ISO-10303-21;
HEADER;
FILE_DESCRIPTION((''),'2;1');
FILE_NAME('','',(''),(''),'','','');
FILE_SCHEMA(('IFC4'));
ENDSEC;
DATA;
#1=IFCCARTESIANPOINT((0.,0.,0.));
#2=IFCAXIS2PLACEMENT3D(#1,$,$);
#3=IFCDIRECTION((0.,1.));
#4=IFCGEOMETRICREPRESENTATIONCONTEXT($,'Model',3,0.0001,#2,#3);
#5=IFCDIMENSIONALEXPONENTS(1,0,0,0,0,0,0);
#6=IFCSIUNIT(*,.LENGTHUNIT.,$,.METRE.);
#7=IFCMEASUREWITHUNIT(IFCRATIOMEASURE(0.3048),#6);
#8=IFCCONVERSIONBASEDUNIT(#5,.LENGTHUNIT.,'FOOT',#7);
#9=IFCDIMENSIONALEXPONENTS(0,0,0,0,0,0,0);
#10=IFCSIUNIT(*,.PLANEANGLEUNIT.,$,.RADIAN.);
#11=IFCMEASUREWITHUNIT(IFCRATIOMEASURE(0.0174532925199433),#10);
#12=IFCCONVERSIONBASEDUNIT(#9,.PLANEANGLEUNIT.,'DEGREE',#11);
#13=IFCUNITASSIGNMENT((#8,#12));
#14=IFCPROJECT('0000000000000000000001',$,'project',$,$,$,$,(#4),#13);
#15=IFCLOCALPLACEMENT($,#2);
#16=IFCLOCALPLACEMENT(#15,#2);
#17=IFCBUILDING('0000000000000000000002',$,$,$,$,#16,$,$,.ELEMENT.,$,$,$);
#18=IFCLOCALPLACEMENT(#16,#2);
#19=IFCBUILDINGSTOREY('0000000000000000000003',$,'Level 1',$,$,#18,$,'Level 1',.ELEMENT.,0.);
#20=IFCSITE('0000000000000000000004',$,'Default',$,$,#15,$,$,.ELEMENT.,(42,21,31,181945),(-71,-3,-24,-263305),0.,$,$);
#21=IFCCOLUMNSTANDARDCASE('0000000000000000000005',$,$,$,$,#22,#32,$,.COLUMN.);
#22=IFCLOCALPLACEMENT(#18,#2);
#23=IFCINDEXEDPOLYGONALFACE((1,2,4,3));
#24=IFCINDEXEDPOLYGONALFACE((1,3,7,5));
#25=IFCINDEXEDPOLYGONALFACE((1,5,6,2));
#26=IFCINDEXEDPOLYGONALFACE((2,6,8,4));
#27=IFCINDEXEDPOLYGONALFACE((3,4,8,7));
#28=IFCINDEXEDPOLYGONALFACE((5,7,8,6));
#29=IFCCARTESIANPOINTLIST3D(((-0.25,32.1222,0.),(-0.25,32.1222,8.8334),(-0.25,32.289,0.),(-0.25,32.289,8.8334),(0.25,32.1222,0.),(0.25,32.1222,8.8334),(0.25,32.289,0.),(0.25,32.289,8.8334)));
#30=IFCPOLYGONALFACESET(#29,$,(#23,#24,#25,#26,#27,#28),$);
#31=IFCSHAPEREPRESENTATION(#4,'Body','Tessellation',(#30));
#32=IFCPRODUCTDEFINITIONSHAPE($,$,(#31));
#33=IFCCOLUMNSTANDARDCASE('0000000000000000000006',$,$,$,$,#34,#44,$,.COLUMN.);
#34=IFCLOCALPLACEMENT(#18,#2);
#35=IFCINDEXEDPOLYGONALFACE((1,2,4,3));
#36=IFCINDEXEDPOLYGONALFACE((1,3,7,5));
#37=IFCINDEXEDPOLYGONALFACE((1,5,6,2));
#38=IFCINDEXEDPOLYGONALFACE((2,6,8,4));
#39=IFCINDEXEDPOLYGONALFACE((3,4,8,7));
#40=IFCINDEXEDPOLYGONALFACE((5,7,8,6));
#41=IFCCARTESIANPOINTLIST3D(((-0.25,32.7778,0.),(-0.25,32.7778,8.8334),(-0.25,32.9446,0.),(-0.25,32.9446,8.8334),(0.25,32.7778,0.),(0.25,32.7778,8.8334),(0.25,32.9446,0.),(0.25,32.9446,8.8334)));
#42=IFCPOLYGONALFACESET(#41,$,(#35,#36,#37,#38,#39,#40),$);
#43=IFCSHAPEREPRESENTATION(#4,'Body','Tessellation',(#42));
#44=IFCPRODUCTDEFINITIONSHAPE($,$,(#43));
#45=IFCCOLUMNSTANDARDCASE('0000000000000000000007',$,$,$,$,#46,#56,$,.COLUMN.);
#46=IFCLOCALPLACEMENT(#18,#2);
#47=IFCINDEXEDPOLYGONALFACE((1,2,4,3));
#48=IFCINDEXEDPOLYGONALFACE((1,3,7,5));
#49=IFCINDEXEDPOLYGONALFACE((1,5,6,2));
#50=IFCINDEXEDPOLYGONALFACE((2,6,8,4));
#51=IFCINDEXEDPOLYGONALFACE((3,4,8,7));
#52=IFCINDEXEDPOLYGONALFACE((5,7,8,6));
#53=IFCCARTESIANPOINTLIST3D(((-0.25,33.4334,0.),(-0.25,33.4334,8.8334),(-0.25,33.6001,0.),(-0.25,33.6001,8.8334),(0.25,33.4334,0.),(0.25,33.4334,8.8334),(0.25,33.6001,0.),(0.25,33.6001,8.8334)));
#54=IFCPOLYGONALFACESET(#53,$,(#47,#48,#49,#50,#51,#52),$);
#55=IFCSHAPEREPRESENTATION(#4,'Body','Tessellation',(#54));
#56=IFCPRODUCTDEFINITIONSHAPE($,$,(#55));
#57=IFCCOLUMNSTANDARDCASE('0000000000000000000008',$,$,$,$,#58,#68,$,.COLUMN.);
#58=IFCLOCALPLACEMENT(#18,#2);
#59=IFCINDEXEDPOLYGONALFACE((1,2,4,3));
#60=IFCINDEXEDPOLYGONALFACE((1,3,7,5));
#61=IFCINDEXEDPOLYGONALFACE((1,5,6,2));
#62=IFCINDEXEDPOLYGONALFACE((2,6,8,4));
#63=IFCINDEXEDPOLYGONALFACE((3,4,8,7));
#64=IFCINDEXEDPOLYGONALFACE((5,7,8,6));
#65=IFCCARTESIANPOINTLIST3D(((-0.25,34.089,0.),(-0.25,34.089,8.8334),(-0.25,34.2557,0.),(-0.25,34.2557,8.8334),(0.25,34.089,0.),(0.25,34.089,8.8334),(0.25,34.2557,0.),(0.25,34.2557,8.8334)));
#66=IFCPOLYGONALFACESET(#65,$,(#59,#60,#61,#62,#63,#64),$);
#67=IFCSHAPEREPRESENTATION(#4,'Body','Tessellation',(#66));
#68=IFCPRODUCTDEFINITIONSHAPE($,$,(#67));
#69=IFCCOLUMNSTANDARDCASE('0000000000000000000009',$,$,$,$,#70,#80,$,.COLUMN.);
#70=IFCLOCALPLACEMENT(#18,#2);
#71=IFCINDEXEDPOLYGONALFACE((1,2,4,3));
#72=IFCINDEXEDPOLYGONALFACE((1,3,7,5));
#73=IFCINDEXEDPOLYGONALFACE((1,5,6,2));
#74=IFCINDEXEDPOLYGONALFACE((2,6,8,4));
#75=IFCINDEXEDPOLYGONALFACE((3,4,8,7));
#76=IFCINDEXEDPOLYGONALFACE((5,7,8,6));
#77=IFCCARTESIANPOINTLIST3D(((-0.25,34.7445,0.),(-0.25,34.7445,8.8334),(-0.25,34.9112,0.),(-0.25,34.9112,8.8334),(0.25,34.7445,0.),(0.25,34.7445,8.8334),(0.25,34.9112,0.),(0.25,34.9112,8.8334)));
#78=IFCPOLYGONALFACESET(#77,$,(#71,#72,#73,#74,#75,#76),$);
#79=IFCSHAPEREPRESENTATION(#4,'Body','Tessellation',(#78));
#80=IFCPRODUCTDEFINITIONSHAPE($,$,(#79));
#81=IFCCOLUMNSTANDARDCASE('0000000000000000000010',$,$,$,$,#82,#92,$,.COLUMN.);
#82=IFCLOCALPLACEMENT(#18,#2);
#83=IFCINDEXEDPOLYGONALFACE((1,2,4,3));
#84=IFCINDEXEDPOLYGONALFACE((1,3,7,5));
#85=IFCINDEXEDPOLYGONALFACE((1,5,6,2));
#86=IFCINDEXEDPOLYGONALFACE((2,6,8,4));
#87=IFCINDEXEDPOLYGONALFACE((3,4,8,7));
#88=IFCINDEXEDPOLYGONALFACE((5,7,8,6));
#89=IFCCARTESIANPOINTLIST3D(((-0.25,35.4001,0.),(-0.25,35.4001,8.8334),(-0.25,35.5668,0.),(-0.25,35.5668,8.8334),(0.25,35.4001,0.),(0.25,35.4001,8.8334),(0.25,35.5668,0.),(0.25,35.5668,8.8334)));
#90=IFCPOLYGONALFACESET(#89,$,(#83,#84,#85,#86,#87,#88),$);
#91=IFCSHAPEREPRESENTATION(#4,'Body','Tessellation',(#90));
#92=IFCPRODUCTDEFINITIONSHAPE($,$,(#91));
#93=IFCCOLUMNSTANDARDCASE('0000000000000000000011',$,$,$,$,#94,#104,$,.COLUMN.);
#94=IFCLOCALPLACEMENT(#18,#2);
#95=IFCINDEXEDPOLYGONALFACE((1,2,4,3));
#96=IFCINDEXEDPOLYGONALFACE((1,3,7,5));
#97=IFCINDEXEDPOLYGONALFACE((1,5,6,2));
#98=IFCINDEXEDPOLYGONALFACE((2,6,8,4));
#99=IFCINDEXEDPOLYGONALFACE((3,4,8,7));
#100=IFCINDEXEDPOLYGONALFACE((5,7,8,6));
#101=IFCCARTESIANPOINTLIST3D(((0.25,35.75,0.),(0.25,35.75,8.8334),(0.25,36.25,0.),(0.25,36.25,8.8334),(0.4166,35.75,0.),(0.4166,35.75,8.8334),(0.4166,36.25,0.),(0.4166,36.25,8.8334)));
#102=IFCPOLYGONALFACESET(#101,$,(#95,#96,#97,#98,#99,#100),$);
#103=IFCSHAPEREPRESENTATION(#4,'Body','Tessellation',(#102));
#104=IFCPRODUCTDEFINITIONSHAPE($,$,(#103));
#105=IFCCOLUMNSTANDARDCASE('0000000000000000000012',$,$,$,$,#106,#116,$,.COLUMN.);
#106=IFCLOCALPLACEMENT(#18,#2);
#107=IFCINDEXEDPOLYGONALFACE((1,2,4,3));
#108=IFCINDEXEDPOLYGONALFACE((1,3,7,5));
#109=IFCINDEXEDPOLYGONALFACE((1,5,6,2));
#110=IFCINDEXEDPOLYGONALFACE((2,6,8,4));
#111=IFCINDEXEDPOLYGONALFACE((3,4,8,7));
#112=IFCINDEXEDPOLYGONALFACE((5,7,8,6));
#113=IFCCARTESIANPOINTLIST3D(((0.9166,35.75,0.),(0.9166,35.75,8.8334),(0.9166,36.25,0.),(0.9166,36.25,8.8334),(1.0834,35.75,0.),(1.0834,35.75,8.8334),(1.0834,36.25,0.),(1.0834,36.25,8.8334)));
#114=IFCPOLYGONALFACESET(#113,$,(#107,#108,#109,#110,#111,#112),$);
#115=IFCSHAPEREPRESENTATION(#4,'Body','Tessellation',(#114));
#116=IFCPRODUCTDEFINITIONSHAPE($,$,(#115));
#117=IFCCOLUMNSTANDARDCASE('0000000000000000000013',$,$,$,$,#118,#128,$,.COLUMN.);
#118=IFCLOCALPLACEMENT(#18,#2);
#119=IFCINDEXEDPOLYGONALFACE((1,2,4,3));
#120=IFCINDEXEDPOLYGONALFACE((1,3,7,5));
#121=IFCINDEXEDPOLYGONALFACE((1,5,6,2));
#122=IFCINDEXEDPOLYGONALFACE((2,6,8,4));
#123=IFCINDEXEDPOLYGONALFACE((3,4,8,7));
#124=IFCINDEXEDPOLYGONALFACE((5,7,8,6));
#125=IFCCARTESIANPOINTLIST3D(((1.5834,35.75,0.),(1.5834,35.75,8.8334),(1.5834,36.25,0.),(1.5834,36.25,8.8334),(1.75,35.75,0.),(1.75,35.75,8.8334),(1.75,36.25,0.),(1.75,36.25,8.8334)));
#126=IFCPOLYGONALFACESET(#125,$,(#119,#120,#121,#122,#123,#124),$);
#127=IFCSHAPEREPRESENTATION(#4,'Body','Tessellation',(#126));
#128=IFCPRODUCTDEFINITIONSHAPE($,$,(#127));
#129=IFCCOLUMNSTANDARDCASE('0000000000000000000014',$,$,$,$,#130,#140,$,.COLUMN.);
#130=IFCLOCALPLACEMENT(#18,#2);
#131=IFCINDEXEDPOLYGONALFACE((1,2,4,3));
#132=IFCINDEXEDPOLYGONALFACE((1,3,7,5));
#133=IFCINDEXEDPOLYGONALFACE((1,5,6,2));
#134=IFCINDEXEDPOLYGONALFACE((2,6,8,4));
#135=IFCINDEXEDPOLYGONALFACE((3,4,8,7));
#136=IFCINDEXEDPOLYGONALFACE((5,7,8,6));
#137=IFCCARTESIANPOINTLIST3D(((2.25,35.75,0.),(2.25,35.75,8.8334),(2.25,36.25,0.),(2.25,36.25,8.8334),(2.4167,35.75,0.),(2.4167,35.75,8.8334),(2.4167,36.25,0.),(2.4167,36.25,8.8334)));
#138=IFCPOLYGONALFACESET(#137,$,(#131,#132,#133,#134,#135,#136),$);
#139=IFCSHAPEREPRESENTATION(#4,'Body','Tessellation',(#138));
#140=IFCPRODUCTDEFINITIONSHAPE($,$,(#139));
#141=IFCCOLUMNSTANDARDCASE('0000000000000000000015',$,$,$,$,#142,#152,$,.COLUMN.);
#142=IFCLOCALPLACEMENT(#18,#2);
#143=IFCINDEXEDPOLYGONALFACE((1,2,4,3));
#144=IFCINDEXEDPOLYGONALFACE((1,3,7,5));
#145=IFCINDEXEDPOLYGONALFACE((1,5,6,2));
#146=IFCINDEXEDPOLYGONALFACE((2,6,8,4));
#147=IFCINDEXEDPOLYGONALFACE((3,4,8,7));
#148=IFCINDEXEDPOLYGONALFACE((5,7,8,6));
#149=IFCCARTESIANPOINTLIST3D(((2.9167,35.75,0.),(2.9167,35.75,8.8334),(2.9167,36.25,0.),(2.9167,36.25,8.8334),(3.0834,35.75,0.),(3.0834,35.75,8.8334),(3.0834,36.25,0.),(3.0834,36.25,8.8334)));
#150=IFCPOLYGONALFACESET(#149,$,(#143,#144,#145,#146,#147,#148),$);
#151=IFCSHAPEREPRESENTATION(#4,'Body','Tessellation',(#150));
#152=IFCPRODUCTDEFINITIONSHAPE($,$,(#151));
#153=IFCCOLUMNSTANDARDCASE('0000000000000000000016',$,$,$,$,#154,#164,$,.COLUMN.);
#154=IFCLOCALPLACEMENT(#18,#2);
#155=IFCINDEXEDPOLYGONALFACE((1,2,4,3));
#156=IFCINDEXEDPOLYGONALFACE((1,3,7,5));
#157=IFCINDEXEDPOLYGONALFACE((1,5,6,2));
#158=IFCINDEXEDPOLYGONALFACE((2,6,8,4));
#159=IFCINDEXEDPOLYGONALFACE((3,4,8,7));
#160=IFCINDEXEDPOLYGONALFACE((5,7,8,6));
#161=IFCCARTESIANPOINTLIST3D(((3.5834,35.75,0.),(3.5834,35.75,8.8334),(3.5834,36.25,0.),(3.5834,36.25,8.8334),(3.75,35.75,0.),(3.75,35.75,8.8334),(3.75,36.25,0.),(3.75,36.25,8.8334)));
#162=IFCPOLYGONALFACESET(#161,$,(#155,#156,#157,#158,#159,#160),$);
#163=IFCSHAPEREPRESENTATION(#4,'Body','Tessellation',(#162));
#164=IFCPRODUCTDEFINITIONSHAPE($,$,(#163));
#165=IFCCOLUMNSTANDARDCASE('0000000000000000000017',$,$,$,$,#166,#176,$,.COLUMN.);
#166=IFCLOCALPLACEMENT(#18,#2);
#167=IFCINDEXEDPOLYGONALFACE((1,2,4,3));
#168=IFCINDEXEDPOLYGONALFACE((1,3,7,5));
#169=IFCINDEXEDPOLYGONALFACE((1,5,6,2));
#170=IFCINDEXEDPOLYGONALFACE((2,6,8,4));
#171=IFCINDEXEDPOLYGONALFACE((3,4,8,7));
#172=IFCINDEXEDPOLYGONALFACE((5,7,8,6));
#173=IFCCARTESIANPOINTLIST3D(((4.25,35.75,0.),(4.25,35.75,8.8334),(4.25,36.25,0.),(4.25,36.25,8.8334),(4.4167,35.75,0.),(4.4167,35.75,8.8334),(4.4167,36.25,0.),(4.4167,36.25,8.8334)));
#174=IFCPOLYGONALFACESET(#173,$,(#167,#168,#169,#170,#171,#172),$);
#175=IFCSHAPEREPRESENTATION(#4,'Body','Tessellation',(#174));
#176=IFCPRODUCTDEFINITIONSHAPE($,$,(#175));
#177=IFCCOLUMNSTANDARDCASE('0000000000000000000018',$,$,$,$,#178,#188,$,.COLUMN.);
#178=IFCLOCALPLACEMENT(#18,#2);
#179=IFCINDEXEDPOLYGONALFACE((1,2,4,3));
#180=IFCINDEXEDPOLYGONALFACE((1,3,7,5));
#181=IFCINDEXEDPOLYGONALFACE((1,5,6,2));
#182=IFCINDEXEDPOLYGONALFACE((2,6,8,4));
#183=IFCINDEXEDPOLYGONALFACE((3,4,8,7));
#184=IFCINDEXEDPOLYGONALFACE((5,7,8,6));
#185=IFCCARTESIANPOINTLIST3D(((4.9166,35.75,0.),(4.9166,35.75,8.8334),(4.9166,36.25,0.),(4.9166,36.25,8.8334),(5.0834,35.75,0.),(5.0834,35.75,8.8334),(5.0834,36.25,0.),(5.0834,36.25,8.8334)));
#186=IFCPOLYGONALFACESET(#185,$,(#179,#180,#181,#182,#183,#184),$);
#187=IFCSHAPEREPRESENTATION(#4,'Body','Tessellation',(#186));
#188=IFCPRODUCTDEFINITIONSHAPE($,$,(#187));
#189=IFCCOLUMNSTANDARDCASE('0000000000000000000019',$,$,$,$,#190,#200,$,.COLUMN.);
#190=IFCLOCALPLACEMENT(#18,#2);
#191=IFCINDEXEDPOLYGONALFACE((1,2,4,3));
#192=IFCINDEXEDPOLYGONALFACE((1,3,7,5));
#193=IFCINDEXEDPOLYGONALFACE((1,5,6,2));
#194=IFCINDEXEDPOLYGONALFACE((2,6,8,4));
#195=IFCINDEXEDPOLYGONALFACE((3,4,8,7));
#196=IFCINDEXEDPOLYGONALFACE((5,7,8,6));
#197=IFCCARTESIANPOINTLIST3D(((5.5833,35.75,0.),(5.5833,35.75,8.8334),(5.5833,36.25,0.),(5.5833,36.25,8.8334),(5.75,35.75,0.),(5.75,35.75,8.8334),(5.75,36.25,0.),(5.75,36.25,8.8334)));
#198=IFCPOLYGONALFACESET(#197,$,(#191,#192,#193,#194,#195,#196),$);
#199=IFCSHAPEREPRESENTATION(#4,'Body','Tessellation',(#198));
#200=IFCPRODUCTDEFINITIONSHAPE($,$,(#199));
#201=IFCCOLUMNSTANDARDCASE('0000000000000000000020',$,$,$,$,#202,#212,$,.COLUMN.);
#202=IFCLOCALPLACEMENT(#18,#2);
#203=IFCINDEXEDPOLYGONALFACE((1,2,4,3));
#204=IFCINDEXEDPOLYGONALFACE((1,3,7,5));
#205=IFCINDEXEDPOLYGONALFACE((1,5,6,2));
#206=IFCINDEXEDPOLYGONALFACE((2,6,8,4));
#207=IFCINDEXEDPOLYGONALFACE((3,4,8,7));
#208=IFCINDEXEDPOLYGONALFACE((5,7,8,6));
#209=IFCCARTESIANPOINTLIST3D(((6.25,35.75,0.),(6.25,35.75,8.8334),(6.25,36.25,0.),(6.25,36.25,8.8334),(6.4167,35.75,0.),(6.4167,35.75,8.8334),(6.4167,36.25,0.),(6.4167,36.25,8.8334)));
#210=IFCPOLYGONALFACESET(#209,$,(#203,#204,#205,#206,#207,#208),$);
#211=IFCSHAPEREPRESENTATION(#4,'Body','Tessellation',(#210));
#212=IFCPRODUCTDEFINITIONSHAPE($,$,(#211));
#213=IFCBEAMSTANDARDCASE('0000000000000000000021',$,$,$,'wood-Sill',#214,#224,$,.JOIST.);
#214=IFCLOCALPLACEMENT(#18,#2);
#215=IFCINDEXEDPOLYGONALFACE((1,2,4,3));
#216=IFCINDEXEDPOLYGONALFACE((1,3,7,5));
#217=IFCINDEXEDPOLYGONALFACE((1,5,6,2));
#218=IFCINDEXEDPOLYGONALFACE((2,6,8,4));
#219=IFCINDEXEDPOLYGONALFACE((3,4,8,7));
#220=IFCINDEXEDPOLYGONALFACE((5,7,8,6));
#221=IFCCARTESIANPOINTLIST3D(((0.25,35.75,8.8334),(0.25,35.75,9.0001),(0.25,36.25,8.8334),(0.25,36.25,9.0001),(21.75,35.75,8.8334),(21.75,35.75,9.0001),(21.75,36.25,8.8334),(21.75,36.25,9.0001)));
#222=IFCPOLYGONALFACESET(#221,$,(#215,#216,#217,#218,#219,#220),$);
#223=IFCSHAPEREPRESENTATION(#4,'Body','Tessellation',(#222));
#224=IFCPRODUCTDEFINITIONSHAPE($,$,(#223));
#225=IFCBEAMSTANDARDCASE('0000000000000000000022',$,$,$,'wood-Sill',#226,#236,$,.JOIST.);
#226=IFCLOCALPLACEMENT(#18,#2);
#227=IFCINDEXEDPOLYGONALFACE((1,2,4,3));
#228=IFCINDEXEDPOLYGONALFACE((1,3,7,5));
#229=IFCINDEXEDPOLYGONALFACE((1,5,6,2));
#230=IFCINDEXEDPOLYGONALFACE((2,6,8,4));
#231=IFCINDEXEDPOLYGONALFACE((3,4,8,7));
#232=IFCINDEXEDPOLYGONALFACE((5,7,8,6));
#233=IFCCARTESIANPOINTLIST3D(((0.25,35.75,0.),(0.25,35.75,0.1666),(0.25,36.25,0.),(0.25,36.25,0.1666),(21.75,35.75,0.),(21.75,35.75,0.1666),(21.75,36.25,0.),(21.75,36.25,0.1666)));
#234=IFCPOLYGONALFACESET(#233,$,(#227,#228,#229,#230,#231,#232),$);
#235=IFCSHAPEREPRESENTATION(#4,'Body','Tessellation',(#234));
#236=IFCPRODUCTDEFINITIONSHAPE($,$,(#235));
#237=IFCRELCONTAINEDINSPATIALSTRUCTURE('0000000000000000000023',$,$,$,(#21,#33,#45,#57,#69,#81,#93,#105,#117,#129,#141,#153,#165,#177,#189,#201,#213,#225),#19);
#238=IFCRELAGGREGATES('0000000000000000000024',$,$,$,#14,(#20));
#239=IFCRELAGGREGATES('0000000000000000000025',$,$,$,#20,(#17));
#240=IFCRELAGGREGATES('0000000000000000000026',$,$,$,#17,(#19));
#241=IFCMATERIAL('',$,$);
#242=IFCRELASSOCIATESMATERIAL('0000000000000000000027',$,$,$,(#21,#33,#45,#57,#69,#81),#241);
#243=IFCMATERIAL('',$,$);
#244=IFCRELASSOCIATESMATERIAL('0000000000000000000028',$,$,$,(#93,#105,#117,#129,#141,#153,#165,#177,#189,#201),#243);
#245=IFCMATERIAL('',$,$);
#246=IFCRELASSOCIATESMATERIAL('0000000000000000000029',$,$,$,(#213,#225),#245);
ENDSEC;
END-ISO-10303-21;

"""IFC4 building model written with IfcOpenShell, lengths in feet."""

from ifc_helpers import new_model, entity, si_unit, converted_unit, direction, frame, origin, origin_with_axes, place, context, project, spatial, rectangle, extrude, material, element, save


model = new_model("IFC4")

# Units and contexts
model_context = context("Model", 3, precision=0.0001, world=origin(), true_north=direction((0.0, 1.0)))
ifc_project = project(units=[converted_unit("LENGTHUNIT", "FOOT", entity("IfcRatioMeasure", 0.3048), si_unit("LENGTHUNIT", "METRE"), dimensions=[1, 0, 0, 0, 0, 0, 0]), converted_unit("PLANEANGLEUNIT", "DEGREE", entity("IfcRatioMeasure", 0.0174532925199433), si_unit("PLANEANGLEUNIT", "RADIAN"), dimensions=[0, 0, 0, 0, 0, 0, 0])], contexts=[model_context])

# Site, building, storey
site_placement = place(None, origin())
site = spatial("IfcSite", under=ifc_project, at=site_placement, Name="Default", CompositionType="ELEMENT", RefLatitude=(42, 21, 31, 181945), RefLongitude=(-71, -3, -24, -263305), RefElevation=0.0)
building_placement = place(site_placement, origin())
building = spatial("IfcBuilding", under=site, at=building_placement, CompositionType="ELEMENT")
storey_placement = place(building_placement, origin())
storey = spatial("IfcBuildingStorey", under=building, at=storey_placement, Name="Level 1", LongName="Level 1", CompositionType="ELEMENT", Elevation=0.0)

# Columns
ifc_material_1 = material(Name="")
placement_1 = place(storey_placement, frame((0.0, -0.25, 0.0), z_axis=(0.0, 0.0, 1.0), x_axis=(0.0, 1.0, 0.0)))
for number, where, z_axis, x_axis in (
    (1, (32.4556, 0.0, 0.0), (0.0, 0.0, 1.0), (1.0, 0.0, 0.0)),
    (2, (33.1112, 0.0, 0.0), (0.0, 0.0, 1.0), (1.0, 0.0, 0.0)),
    (3, (33.7667, 0.0, 0.0), (0.0, 0.0, 1.0), (1.0, 0.0, 0.0)),
    (4, (34.4223, 0.0, 0.0), (0.0, 0.0, 1.0), (1.0, 0.0, 0.0)),
    (5, (35.0778, 0.0, 0.0), (0.0, 0.0, 1.0), (1.0, 0.0, 0.0)),
    (6, (35.7334, 0.0, 0.0), (0.0, 0.0, 1.0), (1.0, 0.0, 0.0)),
):
    element("IfcColumnStandardCase", number, at=place(placement_1, frame(where, z_axis=z_axis, x_axis=x_axis)), inside=storey, material=ifc_material_1, PredefinedType="COLUMN", context=model_context, shape_type="SweptSolid", body=[
        extrude(rectangle(XDim=0.1667, YDim=0.5), origin(), (0.0, 0.0, 1.0), 8.8334),
    ])
ifc_material_2 = material(Name="")
placement_2 = place(storey_placement, frame((0.25, 36.0, 0.0)))
for number, where, z_axis, x_axis in (
    (7, (0.0833, 0.0, 0.0), (0.0, 0.0, 1.0), (1.0, 0.0, 0.0)),
    (8, (0.75, 0.0, 0.0), (0.0, 0.0, 1.0), (1.0, 0.0, 0.0)),
    (9, (1.4167, 0.0, 0.0), (0.0, 0.0, 1.0), (1.0, 0.0, 0.0)),
    (10, (2.0833, 0.0, 0.0), (0.0, 0.0, 1.0), (1.0, 0.0, 0.0)),
    (11, (2.75, 0.0, 0.0), (0.0, 0.0, 1.0), (1.0, 0.0, 0.0)),
    (12, (3.4167, 0.0, 0.0), (0.0, 0.0, 1.0), (1.0, 0.0, 0.0)),
    (13, (4.0833, 0.0, 0.0), (0.0, 0.0, 1.0), (1.0, 0.0, 0.0)),
    (14, (4.75, 0.0, 0.0), (0.0, 0.0, 1.0), (1.0, 0.0, 0.0)),
    (15, (5.4167, 0.0, 0.0), (0.0, 0.0, 1.0), (1.0, 0.0, 0.0)),
    (16, (6.0833, 0.0, 0.0), (0.0, 0.0, 1.0), (1.0, 0.0, 0.0)),
):
    element("IfcColumnStandardCase", number, at=place(placement_2, frame(where, z_axis=z_axis, x_axis=x_axis)), inside=storey, material=ifc_material_2, PredefinedType="COLUMN", context=model_context, shape_type="SweptSolid", body=[
        extrude(rectangle(XDim=0.1667, YDim=0.5), origin(), (0.0, 0.0, 1.0), 8.8334),
    ])

# Beams
ifc_material_3 = material(Name="")
for number, where, z_axis, x_axis in (
    (17, (0.0, 0.0, 8.9167), (1.0, 0.0, 0.0), (0.0, 0.0, 1.0)),
    (18, (0.0, 0.0, 0.0833), (1.0, 0.0, 0.0), (0.0, 0.0, 1.0)),
):
    element("IfcBeamStandardCase", number, at=place(placement_2, frame(where, z_axis=z_axis, x_axis=x_axis)), inside=storey, material=ifc_material_3, ObjectType="wood-Sill", PredefinedType="JOIST", context=model_context, shape_type="SweptSolid", body=[
        extrude(rectangle(XDim=0.1667, YDim=0.5), origin_with_axes(), (0.0, 0.0, 1.0), 21.5),
    ])

save(model, "model.ifc")
